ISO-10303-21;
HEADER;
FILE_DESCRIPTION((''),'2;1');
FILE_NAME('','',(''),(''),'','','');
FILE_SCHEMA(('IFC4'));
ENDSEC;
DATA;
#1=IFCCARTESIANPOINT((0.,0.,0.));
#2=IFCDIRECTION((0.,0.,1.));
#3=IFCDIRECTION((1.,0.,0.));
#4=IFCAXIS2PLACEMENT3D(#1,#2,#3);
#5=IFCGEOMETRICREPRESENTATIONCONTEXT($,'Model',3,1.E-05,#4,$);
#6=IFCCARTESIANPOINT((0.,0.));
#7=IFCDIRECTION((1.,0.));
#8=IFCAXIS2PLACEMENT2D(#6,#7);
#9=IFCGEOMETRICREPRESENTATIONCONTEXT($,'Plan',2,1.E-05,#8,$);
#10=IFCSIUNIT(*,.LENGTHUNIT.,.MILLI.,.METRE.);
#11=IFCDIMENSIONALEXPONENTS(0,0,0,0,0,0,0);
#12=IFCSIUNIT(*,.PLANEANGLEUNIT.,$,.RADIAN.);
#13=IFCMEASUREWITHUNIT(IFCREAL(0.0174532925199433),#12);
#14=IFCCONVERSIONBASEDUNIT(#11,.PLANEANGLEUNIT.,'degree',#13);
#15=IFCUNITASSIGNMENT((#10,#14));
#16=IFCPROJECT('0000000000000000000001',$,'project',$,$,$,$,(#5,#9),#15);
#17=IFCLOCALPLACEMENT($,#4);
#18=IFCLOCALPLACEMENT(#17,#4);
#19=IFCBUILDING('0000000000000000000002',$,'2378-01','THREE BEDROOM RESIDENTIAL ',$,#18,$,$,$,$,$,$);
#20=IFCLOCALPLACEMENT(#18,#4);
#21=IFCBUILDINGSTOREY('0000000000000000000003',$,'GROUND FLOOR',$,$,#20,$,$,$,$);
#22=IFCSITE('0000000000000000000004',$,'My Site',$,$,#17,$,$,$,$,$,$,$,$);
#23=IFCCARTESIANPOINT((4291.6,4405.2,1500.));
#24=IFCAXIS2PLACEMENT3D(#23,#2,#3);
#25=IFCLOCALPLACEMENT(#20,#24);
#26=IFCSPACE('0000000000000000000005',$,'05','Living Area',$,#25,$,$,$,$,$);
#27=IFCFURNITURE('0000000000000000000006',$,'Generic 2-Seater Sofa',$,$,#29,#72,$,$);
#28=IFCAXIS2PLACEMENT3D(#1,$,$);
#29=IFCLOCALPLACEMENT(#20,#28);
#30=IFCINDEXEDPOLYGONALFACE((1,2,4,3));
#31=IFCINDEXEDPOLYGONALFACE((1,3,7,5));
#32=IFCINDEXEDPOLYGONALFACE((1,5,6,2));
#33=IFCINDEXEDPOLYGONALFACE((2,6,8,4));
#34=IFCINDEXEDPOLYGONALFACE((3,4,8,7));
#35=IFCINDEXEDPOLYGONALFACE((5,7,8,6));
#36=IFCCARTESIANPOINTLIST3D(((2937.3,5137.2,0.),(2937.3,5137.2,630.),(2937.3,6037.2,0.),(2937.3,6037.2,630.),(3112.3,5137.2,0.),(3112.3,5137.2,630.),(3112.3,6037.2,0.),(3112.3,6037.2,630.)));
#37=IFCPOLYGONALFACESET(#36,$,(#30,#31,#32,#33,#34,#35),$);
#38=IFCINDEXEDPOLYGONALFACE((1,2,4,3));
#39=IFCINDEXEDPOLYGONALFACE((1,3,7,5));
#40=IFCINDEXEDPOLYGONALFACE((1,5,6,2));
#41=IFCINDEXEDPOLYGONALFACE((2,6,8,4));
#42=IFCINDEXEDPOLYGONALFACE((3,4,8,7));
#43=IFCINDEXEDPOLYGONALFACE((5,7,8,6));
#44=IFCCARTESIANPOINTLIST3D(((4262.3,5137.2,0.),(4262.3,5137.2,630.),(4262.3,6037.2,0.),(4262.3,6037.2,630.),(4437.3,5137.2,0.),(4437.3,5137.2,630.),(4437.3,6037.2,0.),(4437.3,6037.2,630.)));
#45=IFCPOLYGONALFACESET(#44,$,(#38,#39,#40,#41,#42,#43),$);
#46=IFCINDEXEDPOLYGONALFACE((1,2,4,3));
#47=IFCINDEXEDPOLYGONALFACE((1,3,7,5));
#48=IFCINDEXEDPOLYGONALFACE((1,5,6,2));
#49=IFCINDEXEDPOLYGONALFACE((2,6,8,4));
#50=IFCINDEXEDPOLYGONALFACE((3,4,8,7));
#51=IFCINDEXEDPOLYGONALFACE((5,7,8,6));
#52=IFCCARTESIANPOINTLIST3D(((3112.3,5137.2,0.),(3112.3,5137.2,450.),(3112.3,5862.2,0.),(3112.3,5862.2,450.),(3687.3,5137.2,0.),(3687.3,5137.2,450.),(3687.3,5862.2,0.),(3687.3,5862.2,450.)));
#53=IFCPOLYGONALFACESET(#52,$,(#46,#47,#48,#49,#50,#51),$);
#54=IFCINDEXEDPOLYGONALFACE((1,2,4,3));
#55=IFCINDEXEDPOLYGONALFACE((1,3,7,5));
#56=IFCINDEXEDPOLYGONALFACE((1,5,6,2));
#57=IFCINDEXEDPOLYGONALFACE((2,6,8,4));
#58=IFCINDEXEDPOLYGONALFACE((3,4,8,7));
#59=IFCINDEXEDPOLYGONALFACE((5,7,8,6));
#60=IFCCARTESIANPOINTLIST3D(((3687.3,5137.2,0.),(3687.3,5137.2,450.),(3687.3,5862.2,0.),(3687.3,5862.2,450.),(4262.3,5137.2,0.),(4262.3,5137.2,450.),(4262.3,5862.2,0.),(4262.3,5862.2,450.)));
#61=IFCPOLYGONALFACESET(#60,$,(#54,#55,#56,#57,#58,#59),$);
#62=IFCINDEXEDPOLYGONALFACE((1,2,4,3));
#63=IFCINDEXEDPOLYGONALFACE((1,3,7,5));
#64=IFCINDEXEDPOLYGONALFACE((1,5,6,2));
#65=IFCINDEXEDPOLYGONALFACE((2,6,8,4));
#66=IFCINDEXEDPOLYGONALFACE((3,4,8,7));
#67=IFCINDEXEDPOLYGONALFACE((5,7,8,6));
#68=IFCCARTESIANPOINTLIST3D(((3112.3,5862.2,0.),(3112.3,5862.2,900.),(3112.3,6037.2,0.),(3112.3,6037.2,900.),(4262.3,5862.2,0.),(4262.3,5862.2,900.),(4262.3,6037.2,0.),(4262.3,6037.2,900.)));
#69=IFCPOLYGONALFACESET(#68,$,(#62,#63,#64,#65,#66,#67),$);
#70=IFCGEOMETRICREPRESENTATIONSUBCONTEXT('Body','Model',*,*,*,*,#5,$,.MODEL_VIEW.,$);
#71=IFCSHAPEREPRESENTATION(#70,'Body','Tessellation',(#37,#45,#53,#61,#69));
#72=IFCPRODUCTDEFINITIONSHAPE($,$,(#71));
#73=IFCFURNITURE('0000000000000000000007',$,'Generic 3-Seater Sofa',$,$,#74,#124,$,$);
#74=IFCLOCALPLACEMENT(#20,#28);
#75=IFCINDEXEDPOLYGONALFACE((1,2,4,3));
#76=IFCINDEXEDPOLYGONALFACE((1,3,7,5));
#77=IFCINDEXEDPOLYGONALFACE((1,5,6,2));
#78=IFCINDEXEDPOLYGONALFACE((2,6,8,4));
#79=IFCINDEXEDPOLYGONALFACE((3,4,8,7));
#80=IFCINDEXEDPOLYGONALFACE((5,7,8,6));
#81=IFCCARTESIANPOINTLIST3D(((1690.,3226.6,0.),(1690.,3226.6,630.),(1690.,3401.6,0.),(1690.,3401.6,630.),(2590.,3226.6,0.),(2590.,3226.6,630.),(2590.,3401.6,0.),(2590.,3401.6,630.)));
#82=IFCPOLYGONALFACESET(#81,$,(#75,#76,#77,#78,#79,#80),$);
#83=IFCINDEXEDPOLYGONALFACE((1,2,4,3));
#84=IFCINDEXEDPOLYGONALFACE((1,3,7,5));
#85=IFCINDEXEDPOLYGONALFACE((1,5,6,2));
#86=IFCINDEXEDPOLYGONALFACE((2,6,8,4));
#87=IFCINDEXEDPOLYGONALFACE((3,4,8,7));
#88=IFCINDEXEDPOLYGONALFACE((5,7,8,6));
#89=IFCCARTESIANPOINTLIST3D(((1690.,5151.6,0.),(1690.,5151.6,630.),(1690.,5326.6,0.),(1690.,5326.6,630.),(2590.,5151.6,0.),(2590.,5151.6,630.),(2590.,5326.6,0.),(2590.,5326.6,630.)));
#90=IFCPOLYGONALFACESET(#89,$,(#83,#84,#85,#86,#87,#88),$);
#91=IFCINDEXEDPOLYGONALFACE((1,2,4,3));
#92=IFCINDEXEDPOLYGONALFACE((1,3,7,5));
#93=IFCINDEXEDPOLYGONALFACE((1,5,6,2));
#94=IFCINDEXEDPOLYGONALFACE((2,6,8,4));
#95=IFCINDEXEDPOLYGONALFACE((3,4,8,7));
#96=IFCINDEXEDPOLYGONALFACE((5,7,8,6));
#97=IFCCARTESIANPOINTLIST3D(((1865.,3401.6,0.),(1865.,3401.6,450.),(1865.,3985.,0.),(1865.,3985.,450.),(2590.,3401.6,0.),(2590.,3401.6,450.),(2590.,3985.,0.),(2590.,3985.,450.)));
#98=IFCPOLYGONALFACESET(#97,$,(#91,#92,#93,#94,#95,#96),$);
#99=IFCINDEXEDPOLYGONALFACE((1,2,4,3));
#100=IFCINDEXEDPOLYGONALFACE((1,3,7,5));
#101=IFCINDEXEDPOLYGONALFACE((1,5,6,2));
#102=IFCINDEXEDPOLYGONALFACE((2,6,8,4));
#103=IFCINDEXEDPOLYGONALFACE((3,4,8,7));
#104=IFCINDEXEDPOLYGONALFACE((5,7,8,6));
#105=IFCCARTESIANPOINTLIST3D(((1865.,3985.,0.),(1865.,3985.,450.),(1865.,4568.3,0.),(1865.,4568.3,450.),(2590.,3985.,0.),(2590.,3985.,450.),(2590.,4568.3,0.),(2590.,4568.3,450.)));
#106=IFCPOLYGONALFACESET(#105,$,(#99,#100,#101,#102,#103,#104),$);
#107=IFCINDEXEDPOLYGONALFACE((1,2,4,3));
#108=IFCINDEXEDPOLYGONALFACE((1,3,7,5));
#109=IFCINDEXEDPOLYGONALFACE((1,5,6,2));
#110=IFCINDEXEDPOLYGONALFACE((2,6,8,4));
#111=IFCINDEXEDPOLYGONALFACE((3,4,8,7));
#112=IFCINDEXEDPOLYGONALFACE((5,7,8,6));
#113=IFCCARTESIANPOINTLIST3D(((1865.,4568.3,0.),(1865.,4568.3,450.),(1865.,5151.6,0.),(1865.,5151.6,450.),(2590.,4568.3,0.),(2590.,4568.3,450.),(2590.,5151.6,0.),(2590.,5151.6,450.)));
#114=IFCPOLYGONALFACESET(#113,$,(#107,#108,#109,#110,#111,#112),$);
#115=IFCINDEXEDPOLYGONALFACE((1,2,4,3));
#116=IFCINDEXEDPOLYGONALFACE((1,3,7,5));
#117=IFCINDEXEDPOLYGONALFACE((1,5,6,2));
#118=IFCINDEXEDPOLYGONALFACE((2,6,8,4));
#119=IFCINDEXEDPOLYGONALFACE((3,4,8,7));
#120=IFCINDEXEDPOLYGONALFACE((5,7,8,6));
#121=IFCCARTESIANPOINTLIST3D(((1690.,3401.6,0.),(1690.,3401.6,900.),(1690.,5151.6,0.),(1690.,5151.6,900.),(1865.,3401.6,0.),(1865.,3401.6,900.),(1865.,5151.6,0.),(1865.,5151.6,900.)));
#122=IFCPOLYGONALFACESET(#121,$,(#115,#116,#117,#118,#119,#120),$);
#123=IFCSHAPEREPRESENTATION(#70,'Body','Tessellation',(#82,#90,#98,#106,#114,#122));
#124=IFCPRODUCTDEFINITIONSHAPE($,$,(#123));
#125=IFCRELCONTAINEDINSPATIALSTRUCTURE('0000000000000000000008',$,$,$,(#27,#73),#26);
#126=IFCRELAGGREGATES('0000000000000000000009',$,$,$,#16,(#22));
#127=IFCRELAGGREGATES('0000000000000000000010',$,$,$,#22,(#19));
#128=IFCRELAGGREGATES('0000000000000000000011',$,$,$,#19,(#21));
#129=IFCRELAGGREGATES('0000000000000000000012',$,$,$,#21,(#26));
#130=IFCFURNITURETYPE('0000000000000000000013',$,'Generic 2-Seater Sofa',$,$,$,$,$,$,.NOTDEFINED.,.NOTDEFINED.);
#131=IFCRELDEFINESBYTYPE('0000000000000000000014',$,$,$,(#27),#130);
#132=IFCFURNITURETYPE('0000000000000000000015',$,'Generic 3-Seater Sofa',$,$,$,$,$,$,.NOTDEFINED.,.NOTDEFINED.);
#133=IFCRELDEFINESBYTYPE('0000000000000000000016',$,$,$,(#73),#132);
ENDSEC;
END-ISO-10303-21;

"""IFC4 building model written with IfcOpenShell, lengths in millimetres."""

from ifc_helpers import new_model, entity, si_unit, converted_unit, frame, origin_with_axes, origin_2d_with_axis, place, context, subcontext, project, spatial, line, indexed_curve, outline, extrude, shape, source, transform, mapped, type_object, type_shapes, element, save


model = new_model("IFC4")

# Units and contexts
model_context = context("Model", 3, precision=1e-05, world=origin_with_axes())
plan_context = context("Plan", 2, precision=1e-05, world=origin_2d_with_axis())
body_context_1 = subcontext(model_context, "Body", "Model", "MODEL_VIEW")
body_context_2 = subcontext(plan_context, "Body", "Plan", "PLAN_VIEW")
ifc_project = project(units=[si_unit("LENGTHUNIT", "METRE", prefix="MILLI"), converted_unit("PLANEANGLEUNIT", "degree", entity("IfcReal", 0.0174532925199433), si_unit("PLANEANGLEUNIT", "RADIAN"), dimensions=[0, 0, 0, 0, 0, 0, 0])], contexts=[model_context, plan_context])

# Site, building, storey
site_placement = place(None, origin_with_axes())
site = spatial("IfcSite", under=ifc_project, at=site_placement, Name="My Site")
building_placement = place(site_placement, origin_with_axes())
building = spatial("IfcBuilding", under=site, at=building_placement, Name="2378-01", Description="THREE BEDROOM RESIDENTIAL ")
storey_placement = place(building_placement, origin_with_axes())
storey = spatial("IfcBuildingStorey", under=building, at=storey_placement, Name="GROUND FLOOR")

# Shared definitions
space_1_placement = place(storey_placement, frame((4291.6, 4405.2, 1500.0), z_axis=(0.0, 0.0, 1.0), x_axis=(1.0, 0.0, 0.0)))
space_1 = spatial("IfcSpace", under=storey, at=space_1_placement, Name="05", Description="Living Area")

# Furniture
furniture_type_1 = type_object("IfcFurnitureType", Name="Generic 2-Seater Sofa", AssemblyPlace="NOTDEFINED", PredefinedType="NOTDEFINED")
shared_shape_1 = source(origin_with_axes(), body_context_1, "Body", "SweptSolid", [
    extrude(outline(indexed_curve([(0.0, 0.0), (175.0, 0.0), (175.0, 900.0), (0.0, 900.0)], segments=[line(1, 2, 3, 4, 1)])), frame((-750.0, -900.0, 0.0), z_axis=(0.0, 0.0, 1.0), x_axis=(1.0, 0.0, 0.0)), (0.0, 0.0, 1.0), 630.0),
    extrude(outline(indexed_curve([(0.0, 0.0), (175.0, 0.0), (175.0, 900.0), (0.0, 900.0)], segments=[line(1, 2, 3, 4, 1)])), frame((575.0, -900.0, 0.0), z_axis=(0.0, 0.0, 1.0), x_axis=(1.0, 0.0, 0.0)), (0.0, 0.0, 1.0), 630.0),
    extrude(outline(indexed_curve([(175.0, 0.0), (750.0, 0.0), (750.0, 725.0), (175.0, 725.0)], segments=[line(1, 2, 3, 4, 1)])), frame((-750.0, -900.0, 0.0), z_axis=(0.0, 0.0, 1.0), x_axis=(1.0, 0.0, 0.0)), (0.0, 0.0, 1.0), 450.0),
    extrude(outline(indexed_curve([(750.0, 0.0), (1325.0, 0.0), (1325.0, 725.0), (750.0, 725.0)], segments=[line(1, 2, 3, 4, 1)])), frame((-750.0, -900.0, 0.0), z_axis=(0.0, 0.0, 1.0), x_axis=(1.0, 0.0, 0.0)), (0.0, 0.0, 1.0), 450.0),
    extrude(outline(indexed_curve([(175.0, 725.0), (1325.0, 725.0), (1325.0, 900.0), (175.0, 900.0)], segments=[line(1, 2, 3, 4, 1)])), frame((-750.0, -900.0, 0.0), z_axis=(0.0, 0.0, 1.0), x_axis=(1.0, 0.0, 0.0)), (0.0, 0.0, 1.0), 900.0),
])
shared_shape_2 = source(origin_with_axes(), body_context_2, "Body", "Curve2D", [
    entity("IfcIndexedPolyCurve", entity("IfcCartesianPointList2D", [[-750.0, -900.0], [-575.0, -900.0], [-575.0, 0.0], [-750.0, 0.0]]), [entity("IfcLineIndex", [1, 2, 3, 4, 1])]),
    entity("IfcIndexedPolyCurve", entity("IfcCartesianPointList2D", [[575.0, -900.0], [750.0, -900.0], [750.0, 0.0], [575.0, 0.0]]), [entity("IfcLineIndex", [1, 2, 3, 4, 1])]),
    entity("IfcIndexedPolyCurve", entity("IfcCartesianPointList2D", [[-575.0, -900.0], [0.0, -900.0], [0.0, -175.0], [-575.0, -175.0]]), [entity("IfcLineIndex", [1, 2, 3, 4, 1])]),
    entity("IfcIndexedPolyCurve", entity("IfcCartesianPointList2D", [[0.0, -900.0], [575.0, -900.0], [575.0, -175.0], [0.0, -175.0]]), [entity("IfcLineIndex", [1, 2, 3, 4, 1])]),
    entity("IfcIndexedPolyCurve", entity("IfcCartesianPointList2D", [[-575.0, -175.0], [575.0, -175.0], [575.0, 0.0], [-575.0, 0.0]]), [entity("IfcLineIndex", [1, 2, 3, 4, 1])]),
])
type_shapes(furniture_type_1, [shared_shape_1, shared_shape_2])
furniture_1_placement = place(space_1_placement, frame((-604.4, 1632.0, -1500.0), z_axis=(0.0, 0.0, 1.0), x_axis=(1.0, 0.0, 0.0)))
element("IfcFurniture", 1, at=furniture_1_placement, inside=space_1, type_object=furniture_type_1, Name="Generic 2-Seater Sofa", shapes=[
    shape(body_context_1, "Body", "MappedRepresentation", [mapped(shared_shape_1, transform((0.0, 0.0, 0.0), x_axis=(1.0, 0.0, 0.0), y_axis=(0.0, 1.0, 0.0), z_axis=(0.0, 0.0, 1.0), scale=1.0))]),
    shape(body_context_2, "Body", "MappedRepresentation", [mapped(shared_shape_2, transform((0.0, 0.0, 0.0), x_axis=(1.0, 0.0, 0.0), y_axis=(0.0, 1.0, 0.0), z_axis=(0.0, 0.0, 1.0), scale=1.0))]),
])
furniture_type_2 = type_object("IfcFurnitureType", Name="Generic 3-Seater Sofa", AssemblyPlace="NOTDEFINED", PredefinedType="NOTDEFINED")
shared_shape_3 = source(origin_with_axes(), body_context_1, "Body", "SweptSolid", [
    extrude(outline(indexed_curve([(0.0, 0.0), (175.0, 0.0), (175.0, 900.0), (0.0, 900.0)], segments=[line(1, 2, 3, 4, 1)])), frame((-1050.0, -900.0, 0.0), z_axis=(0.0, 0.0, 1.0), x_axis=(1.0, 0.0, 0.0)), (0.0, 0.0, 1.0), 630.0),
    extrude(outline(indexed_curve([(0.0, 0.0), (175.0, 0.0), (175.0, 900.0), (0.0, 900.0)], segments=[line(1, 2, 3, 4, 1)])), frame((875.0, -900.0, 0.0), z_axis=(0.0, 0.0, 1.0), x_axis=(1.0, 0.0, 0.0)), (0.0, 0.0, 1.0), 630.0),
    extrude(outline(indexed_curve([(175.0, 0.0), (758.3, 0.0), (758.3, 725.0), (175.0, 725.0)], segments=[line(1, 2, 3, 4, 1)])), frame((-1050.0, -900.0, 0.0), z_axis=(0.0, 0.0, 1.0), x_axis=(1.0, 0.0, 0.0)), (0.0, 0.0, 1.0), 450.0),
    extrude(outline(indexed_curve([(758.3, 0.0), (1341.7, 0.0), (1341.7, 725.0), (758.3, 725.0)], segments=[line(1, 2, 3, 4, 1)])), frame((-1050.0, -900.0, 0.0), z_axis=(0.0, 0.0, 1.0), x_axis=(1.0, 0.0, 0.0)), (0.0, 0.0, 1.0), 450.0),
    extrude(outline(indexed_curve([(1341.7, 0.0), (1925.0, 0.0), (1925.0, 725.0), (1341.7, 725.0)], segments=[line(1, 2, 3, 4, 1)])), frame((-1050.0, -900.0, 0.0), z_axis=(0.0, 0.0, 1.0), x_axis=(1.0, 0.0, 0.0)), (0.0, 0.0, 1.0), 450.0),
    extrude(outline(indexed_curve([(175.0, 725.0), (1925.0, 725.0), (1925.0, 900.0), (175.0, 900.0)], segments=[line(1, 2, 3, 4, 1)])), frame((-1050.0, -900.0, 0.0), z_axis=(0.0, 0.0, 1.0), x_axis=(1.0, 0.0, 0.0)), (0.0, 0.0, 1.0), 900.0),
])
shared_shape_4 = source(origin_with_axes(), body_context_2, "Body", "Curve2D", [
    entity("IfcIndexedPolyCurve", entity("IfcCartesianPointList2D", [[-1050.0, -900.0], [-875.0, -900.0], [-875.0, 0.0], [-1050.0, 0.0]]), [entity("IfcLineIndex", [1, 2, 3, 4, 1])]),
    entity("IfcIndexedPolyCurve", entity("IfcCartesianPointList2D", [[875.0, -900.0], [1050.0, -900.0], [1050.0, 0.0], [875.0, 0.0]]), [entity("IfcLineIndex", [1, 2, 3, 4, 1])]),
    entity("IfcIndexedPolyCurve", entity("IfcCartesianPointList2D", [[-875.0, -900.0], [-291.7, -900.0], [-291.7, -175.0], [-875.0, -175.0]]), [entity("IfcLineIndex", [1, 2, 3, 4, 1])]),
    entity("IfcIndexedPolyCurve", entity("IfcCartesianPointList2D", [[-291.7, -900.0], [291.7, -900.0], [291.7, -175.0], [-291.7, -175.0]]), [entity("IfcLineIndex", [1, 2, 3, 4, 1])]),
    entity("IfcIndexedPolyCurve", entity("IfcCartesianPointList2D", [[291.7, -900.0], [875.0, -900.0], [875.0, -175.0], [291.7, -175.0]]), [entity("IfcLineIndex", [1, 2, 3, 4, 1])]),
    entity("IfcIndexedPolyCurve", entity("IfcCartesianPointList2D", [[-875.0, -175.0], [875.0, -175.0], [875.0, 0.0], [-875.0, 0.0]]), [entity("IfcLineIndex", [1, 2, 3, 4, 1])]),
])
type_shapes(furniture_type_2, [shared_shape_3, shared_shape_4])
furniture_2_placement = place(space_1_placement, frame((-2601.6, -128.5, -1500.0), z_axis=(0.0, 0.0, 1.0), x_axis=(0.0, 1.0, 0.0)))
element("IfcFurniture", 2, at=furniture_2_placement, inside=space_1, type_object=furniture_type_2, Name="Generic 3-Seater Sofa", shapes=[
    shape(body_context_1, "Body", "MappedRepresentation", [mapped(shared_shape_3, transform((0.0, 0.0, 0.0), x_axis=(1.0, 0.0, 0.0), y_axis=(0.0, 1.0, 0.0), z_axis=(0.0, 0.0, 1.0), scale=1.0))]),
    shape(body_context_2, "Body", "MappedRepresentation", [mapped(shared_shape_4, transform((0.0, 0.0, 0.0), x_axis=(1.0, 0.0, 0.0), y_axis=(0.0, 1.0, 0.0), z_axis=(0.0, 0.0, 1.0), scale=1.0))]),
])

save(model, "model.ifc")
